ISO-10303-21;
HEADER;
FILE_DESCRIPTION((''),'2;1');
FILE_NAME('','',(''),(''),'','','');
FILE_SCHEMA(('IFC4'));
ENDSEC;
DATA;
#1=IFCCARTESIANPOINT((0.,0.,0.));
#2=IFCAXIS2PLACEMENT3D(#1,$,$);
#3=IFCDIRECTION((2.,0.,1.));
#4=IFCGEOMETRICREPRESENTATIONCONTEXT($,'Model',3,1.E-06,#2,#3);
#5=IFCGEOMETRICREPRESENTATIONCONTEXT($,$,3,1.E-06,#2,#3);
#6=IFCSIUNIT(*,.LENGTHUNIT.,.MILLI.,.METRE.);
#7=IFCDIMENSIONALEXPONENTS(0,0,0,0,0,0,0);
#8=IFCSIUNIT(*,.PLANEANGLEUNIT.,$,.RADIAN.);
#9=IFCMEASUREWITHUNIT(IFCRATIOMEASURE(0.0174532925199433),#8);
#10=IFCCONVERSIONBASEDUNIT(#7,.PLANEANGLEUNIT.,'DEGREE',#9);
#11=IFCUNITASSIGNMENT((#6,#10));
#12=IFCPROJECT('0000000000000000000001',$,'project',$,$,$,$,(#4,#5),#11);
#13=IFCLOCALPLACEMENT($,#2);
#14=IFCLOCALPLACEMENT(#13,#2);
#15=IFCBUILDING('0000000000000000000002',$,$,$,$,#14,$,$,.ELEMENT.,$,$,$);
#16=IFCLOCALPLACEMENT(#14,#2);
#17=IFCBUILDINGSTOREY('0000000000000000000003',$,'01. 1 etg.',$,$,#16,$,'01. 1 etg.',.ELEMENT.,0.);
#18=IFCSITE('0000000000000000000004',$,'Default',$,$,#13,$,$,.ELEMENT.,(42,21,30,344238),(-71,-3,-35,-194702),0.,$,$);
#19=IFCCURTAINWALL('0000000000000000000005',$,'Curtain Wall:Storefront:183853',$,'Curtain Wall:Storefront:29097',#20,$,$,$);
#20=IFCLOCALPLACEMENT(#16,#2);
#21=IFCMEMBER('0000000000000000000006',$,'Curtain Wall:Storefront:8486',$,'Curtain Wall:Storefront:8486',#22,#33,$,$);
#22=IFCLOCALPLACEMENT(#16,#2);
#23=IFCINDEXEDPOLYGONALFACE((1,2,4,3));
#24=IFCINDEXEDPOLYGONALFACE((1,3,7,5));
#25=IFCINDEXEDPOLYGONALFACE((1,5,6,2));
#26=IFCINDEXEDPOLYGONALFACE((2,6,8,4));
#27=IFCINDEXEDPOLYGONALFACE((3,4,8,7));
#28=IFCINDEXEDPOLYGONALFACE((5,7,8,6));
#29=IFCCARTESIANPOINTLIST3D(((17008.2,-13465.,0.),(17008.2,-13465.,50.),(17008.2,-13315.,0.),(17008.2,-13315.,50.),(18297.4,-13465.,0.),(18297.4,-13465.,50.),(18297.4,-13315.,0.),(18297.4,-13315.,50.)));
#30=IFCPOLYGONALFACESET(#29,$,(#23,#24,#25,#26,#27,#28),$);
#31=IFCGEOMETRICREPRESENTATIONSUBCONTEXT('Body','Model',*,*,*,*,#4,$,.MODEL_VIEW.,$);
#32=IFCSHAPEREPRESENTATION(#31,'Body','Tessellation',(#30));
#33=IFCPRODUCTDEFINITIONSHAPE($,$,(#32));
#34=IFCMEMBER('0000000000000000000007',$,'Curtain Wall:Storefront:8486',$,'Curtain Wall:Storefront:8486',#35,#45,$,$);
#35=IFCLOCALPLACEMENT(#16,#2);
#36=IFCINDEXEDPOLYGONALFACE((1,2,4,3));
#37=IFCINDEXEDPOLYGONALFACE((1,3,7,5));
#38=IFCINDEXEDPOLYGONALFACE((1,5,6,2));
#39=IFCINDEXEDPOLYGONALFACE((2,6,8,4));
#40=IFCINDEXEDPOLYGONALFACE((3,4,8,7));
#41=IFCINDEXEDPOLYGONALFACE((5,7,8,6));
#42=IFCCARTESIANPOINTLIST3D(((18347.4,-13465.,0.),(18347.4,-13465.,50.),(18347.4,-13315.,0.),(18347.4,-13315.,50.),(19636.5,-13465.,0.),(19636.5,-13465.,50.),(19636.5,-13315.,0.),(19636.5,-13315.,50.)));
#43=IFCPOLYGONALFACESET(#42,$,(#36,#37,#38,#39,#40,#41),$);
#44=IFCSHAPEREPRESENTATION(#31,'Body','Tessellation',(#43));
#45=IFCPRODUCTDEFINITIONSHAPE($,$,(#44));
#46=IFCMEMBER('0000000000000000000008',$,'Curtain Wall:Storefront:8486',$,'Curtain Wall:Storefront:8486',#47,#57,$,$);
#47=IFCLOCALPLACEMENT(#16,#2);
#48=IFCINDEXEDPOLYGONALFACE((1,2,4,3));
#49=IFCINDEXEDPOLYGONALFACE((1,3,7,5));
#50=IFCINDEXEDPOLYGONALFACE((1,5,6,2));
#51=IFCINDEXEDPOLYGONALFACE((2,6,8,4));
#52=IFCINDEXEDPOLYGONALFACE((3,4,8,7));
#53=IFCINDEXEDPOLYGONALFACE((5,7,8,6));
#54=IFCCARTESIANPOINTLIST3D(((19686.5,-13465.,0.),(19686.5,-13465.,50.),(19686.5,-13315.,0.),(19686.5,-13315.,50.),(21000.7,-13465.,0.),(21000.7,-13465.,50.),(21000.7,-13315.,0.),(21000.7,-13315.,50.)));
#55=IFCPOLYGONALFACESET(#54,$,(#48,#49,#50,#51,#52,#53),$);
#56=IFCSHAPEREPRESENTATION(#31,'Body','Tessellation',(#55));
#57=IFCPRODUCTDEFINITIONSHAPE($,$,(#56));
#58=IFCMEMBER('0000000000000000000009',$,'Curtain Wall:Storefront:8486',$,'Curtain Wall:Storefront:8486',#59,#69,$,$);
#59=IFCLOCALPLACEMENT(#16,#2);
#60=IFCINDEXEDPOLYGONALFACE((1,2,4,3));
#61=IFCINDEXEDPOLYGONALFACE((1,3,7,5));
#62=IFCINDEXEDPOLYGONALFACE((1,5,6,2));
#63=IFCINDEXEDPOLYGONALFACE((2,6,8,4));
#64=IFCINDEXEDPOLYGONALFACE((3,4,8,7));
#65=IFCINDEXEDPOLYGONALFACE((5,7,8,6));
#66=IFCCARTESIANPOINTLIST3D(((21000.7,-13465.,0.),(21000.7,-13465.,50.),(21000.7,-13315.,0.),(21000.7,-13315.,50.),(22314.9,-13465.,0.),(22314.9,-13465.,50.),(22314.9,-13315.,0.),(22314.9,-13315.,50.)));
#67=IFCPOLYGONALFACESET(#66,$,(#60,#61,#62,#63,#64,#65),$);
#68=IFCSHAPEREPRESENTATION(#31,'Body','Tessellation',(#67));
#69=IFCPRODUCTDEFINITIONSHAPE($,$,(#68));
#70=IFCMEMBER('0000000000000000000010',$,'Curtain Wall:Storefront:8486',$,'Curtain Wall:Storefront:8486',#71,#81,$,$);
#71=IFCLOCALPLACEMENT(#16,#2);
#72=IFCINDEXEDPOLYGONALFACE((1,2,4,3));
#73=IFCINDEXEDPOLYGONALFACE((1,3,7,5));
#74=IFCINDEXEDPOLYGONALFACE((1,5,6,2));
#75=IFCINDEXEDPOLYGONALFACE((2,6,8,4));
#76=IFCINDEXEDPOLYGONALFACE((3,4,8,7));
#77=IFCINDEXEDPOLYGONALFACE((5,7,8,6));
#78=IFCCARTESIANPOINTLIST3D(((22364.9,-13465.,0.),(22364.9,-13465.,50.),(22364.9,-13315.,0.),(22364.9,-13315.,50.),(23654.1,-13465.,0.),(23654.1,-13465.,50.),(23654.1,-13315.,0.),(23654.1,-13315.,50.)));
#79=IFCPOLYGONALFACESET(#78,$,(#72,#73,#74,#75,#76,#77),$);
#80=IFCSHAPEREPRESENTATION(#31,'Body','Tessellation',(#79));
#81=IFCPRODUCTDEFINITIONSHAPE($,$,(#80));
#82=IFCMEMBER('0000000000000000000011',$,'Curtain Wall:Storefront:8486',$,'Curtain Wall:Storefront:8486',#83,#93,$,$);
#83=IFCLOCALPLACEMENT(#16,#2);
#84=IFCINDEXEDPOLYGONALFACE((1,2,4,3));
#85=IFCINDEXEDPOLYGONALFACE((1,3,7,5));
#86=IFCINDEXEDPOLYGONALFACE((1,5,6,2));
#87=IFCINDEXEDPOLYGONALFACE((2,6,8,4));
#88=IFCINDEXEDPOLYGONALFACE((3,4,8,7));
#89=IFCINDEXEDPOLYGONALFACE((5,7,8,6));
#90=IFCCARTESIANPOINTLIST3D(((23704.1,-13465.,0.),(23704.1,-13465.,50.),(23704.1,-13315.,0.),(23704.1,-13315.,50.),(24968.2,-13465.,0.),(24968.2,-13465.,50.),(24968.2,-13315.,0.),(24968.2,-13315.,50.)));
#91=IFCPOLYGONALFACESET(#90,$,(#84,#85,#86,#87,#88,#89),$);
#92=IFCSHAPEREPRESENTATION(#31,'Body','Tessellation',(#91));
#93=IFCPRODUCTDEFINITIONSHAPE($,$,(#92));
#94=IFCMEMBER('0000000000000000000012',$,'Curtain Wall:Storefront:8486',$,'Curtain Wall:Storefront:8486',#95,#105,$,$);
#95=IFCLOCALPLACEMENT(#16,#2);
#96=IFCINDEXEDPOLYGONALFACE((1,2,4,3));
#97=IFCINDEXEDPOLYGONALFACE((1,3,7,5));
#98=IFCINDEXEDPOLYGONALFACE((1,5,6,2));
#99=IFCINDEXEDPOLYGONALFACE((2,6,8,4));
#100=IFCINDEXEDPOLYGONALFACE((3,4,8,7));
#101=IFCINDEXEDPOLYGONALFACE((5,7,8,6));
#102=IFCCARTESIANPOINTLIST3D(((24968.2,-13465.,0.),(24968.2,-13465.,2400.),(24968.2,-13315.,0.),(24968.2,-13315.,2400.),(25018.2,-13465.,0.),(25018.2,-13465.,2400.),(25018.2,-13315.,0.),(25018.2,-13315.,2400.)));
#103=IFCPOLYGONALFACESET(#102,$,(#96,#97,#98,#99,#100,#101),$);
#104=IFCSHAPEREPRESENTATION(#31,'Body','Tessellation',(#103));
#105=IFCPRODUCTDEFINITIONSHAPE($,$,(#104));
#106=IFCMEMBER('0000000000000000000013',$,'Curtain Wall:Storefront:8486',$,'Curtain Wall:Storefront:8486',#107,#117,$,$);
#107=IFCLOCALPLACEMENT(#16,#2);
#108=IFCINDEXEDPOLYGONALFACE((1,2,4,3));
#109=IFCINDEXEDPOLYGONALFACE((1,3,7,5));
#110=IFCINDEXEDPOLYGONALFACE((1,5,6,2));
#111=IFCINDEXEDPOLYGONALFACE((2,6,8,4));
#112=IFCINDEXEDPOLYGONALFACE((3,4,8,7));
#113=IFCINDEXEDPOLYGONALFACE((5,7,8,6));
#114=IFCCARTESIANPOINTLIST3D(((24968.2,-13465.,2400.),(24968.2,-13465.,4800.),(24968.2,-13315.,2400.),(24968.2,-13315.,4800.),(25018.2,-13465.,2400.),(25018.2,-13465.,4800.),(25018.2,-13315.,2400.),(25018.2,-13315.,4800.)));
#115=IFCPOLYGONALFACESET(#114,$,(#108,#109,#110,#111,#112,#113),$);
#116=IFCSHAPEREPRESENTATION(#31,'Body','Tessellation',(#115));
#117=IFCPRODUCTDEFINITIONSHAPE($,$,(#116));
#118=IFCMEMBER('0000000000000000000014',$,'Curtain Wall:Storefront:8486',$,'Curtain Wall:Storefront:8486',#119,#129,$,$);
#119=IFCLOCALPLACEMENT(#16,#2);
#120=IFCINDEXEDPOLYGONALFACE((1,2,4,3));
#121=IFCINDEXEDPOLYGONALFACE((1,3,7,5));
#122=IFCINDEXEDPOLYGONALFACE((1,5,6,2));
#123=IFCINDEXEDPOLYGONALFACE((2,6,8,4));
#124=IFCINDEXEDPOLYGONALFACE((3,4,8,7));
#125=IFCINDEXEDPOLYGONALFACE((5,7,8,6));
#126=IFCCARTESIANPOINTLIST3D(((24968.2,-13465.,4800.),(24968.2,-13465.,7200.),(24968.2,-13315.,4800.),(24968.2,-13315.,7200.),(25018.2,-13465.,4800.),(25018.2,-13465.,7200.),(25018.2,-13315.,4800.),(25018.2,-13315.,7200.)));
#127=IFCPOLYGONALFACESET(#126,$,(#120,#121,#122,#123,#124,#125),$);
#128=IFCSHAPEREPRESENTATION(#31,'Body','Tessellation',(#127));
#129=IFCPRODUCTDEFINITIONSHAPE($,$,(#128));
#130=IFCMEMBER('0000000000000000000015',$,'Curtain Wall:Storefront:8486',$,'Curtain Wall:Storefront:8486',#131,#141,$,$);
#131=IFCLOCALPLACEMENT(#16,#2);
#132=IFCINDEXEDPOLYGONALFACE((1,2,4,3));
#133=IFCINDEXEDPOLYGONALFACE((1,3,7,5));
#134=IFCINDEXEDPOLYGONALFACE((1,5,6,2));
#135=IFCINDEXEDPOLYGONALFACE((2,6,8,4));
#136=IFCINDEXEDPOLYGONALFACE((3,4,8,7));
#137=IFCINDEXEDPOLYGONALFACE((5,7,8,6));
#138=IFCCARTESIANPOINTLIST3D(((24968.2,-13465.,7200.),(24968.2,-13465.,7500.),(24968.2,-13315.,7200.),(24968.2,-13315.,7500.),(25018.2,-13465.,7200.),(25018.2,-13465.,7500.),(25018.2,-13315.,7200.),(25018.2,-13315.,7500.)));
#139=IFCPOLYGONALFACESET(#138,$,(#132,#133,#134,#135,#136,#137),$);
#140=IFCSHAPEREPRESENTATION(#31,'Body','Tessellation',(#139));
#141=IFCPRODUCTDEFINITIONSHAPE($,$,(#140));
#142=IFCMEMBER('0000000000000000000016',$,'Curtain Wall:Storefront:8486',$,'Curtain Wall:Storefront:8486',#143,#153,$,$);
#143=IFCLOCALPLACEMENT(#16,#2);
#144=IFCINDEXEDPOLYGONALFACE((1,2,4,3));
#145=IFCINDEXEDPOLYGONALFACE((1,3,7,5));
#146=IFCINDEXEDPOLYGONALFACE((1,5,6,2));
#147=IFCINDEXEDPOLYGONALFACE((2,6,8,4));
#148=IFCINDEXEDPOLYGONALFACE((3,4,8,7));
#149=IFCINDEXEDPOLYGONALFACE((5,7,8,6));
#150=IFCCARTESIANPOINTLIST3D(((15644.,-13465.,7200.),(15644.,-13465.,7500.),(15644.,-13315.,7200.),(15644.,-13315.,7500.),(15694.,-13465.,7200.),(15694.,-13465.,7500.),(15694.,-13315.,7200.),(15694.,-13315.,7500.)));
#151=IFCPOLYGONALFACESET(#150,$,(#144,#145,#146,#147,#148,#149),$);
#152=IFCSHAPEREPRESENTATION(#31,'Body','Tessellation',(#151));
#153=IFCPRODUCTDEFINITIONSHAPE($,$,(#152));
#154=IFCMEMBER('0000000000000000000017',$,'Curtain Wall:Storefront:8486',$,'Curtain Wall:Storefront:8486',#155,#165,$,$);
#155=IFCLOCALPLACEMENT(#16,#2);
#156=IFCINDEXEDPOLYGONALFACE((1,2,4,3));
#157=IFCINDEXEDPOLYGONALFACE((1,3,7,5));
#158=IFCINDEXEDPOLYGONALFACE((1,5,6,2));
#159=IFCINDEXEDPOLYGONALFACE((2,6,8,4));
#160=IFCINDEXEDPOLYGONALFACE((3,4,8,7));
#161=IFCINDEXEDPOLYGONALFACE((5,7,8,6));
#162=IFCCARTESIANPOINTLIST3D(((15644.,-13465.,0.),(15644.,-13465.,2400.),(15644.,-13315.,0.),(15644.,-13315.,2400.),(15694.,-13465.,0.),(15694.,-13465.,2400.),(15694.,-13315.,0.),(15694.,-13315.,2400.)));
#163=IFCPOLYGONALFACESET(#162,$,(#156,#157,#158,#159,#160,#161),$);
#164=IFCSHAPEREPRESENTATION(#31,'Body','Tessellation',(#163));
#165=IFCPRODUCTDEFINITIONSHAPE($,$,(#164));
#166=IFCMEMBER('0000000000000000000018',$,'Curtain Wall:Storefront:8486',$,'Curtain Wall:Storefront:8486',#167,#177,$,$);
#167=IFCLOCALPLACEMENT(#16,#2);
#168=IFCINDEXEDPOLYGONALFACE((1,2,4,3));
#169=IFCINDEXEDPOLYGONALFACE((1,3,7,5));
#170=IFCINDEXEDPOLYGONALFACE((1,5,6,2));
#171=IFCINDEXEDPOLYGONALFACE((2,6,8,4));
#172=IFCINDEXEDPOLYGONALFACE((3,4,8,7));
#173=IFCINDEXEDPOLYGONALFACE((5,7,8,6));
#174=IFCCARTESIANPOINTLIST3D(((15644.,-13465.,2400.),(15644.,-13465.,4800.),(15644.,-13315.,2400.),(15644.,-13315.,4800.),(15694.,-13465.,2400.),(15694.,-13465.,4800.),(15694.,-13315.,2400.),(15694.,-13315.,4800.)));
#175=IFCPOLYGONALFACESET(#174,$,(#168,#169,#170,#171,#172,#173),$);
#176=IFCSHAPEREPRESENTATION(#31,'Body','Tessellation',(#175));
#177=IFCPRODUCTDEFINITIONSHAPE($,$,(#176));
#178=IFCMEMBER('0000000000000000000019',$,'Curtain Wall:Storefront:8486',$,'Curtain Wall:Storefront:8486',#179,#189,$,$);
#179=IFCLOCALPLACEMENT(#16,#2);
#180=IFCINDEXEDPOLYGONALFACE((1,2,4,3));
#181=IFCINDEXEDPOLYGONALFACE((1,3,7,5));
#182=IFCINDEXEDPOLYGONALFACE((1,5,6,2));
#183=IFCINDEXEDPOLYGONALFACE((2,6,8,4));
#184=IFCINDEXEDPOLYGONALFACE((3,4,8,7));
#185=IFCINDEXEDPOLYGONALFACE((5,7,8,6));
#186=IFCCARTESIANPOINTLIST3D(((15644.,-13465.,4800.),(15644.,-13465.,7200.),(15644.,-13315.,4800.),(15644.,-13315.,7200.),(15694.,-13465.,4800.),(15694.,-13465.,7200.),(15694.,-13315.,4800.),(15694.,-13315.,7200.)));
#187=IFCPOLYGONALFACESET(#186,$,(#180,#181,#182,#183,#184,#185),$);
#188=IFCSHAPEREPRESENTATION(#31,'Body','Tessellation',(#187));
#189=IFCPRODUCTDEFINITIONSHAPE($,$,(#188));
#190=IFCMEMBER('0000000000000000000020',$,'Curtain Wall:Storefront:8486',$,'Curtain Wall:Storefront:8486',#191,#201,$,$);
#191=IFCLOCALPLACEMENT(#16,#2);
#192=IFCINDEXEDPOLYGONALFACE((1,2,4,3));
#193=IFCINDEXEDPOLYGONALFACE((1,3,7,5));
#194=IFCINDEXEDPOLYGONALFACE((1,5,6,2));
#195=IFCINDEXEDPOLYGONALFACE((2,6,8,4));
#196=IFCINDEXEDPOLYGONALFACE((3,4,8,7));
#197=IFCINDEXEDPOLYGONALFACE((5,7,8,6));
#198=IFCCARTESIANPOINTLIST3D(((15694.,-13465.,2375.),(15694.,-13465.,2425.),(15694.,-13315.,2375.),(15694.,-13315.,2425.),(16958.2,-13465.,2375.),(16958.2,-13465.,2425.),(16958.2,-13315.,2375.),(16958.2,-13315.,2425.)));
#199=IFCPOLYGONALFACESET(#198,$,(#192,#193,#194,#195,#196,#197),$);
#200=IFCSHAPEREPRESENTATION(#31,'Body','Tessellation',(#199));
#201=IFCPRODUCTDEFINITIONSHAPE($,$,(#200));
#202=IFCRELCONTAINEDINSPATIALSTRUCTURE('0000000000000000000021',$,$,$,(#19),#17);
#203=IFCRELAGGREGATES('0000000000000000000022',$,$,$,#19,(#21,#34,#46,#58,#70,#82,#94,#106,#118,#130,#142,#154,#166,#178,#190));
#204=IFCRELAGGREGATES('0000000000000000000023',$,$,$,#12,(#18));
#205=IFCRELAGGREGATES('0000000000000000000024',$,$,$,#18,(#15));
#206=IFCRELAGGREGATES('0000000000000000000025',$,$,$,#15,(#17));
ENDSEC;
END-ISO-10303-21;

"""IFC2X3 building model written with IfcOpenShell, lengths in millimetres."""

from ifc_helpers import new_model, entity, si_unit, converted_unit, direction, frame, frame_2d, origin, origin_2d_with_axis, place, context, subcontext, project, spatial, rectangle, extrude, element, aggregate, save


model = new_model("IFC2X3")

# Units and contexts
model_context = context("Model", 3, precision=1e-06, world=origin(), true_north=direction((2.0, 0.0, 1.0)))
context_of_model = context(None, 3, precision=1e-06, world=origin(), true_north=direction((2.0, 0.0, 1.0)))
body_context = subcontext(model_context, "Body", "Model", "MODEL_VIEW")
ifc_project = project(units=[si_unit("LENGTHUNIT", "METRE", prefix="MILLI"), converted_unit("PLANEANGLEUNIT", "DEGREE", entity("IfcRatioMeasure", 0.0174532925199433), si_unit("PLANEANGLEUNIT", "RADIAN"), dimensions=[0, 0, 0, 0, 0, 0, 0])], contexts=[model_context, context_of_model])

# Site, building, storey
site_placement = place(None, origin())
site = spatial("IfcSite", under=ifc_project, at=site_placement, Name="Default", CompositionType="ELEMENT", RefLatitude=(42, 21, 30, 344238), RefLongitude=(-71, -3, -35, -194702), RefElevation=0.0)
building_placement = place(site_placement, origin())
building = spatial("IfcBuilding", under=site, at=building_placement, CompositionType="ELEMENT")
storey_placement = place(building_placement, origin())
storey = spatial("IfcBuildingStorey", under=building, at=storey_placement, Name="01. 1 etg.", LongName="01. 1 etg.", CompositionType="ELEMENT", Elevation=0.0)

# Curtain wall, members
curtain_wall_placement = place(storey_placement, origin())
curtain_wall = element("IfcCurtainWall", 1, at=curtain_wall_placement, inside=storey, Name="Curtain Wall:Storefront:183853", ObjectType="Curtain Wall:Storefront:29097")
member_1_placement = place(storey_placement, origin())
member_1 = element("IfcMember", 2, at=member_1_placement, Name="Curtain Wall:Storefront:8486", ObjectType="Curtain Wall:Storefront:8486", context=body_context, shape_type="SweptSolid", body=[
    extrude(rectangle(XDim=1289.2, YDim=150.0, at=frame_2d((0.0, 0.0), x_axis=(1.0, 0.0))), frame((17652.8, -13390.0, 0.0)), (0.0, 0.0, 1.0), 50.0),
])
member_2_placement = place(storey_placement, origin())
member_2 = element("IfcMember", 3, at=member_2_placement, Name="Curtain Wall:Storefront:8486", ObjectType="Curtain Wall:Storefront:8486", context=body_context, shape_type="SweptSolid", body=[
    extrude(rectangle(XDim=1289.2, YDim=150.0, at=frame_2d((0.0, 0.0), x_axis=(1.0, 0.0))), frame((18991.9, -13390.0, 0.0)), (0.0, 0.0, 1.0), 50.0),
])
member_3_placement = place(storey_placement, origin())
member_3 = element("IfcMember", 4, at=member_3_placement, Name="Curtain Wall:Storefront:8486", ObjectType="Curtain Wall:Storefront:8486", context=body_context, shape_type="SweptSolid", body=[
    extrude(rectangle(XDim=1314.2, YDim=150.0, at=origin_2d_with_axis()), frame((20343.6, -13390.0, 0.0)), (0.0, 0.0, 1.0), 50.0),
])
member_4_placement = place(storey_placement, origin())
member_4 = element("IfcMember", 5, at=member_4_placement, Name="Curtain Wall:Storefront:8486", ObjectType="Curtain Wall:Storefront:8486", context=body_context, shape_type="SweptSolid", body=[
    extrude(rectangle(XDim=1314.2, YDim=150.0, at=frame_2d((0.0, 0.0), x_axis=(1.0, 0.0))), frame((21657.8, -13390.0, 0.0)), (0.0, 0.0, 1.0), 50.0),
])
member_5_placement = place(storey_placement, origin())
member_5 = element("IfcMember", 6, at=member_5_placement, Name="Curtain Wall:Storefront:8486", ObjectType="Curtain Wall:Storefront:8486", context=body_context, shape_type="SweptSolid", body=[
    extrude(rectangle(XDim=1289.2, YDim=150.0, at=origin_2d_with_axis()), frame((23009.5, -13390.0, 0.0)), (0.0, 0.0, 1.0), 50.0),
])
member_6_placement = place(storey_placement, origin())
member_6 = element("IfcMember", 7, at=member_6_placement, Name="Curtain Wall:Storefront:8486", ObjectType="Curtain Wall:Storefront:8486", context=body_context, shape_type="SweptSolid", body=[
    extrude(rectangle(XDim=1264.2, YDim=150.0, at=frame_2d((0.0, 0.0), x_axis=(1.0, 0.0))), frame((24336.1, -13390.0, 0.0)), (0.0, 0.0, 1.0), 50.0),
])
member_7_placement = place(storey_placement, origin())
member_7 = element("IfcMember", 8, at=member_7_placement, Name="Curtain Wall:Storefront:8486", ObjectType="Curtain Wall:Storefront:8486", context=body_context, shape_type="SweptSolid", body=[
    extrude(rectangle(XDim=150.0, YDim=50.0, at=frame_2d((0.0, 0.0), x_axis=(1.0, 0.0))), frame((24993.2, -13390.0, 0.0), z_axis=(0.0, 0.0, 1.0), x_axis=(0.0, 1.0, 0.0)), (0.0, 0.0, 1.0), 2400.0),
])
member_8_placement = place(storey_placement, origin())
member_8 = element("IfcMember", 9, at=member_8_placement, Name="Curtain Wall:Storefront:8486", ObjectType="Curtain Wall:Storefront:8486", context=body_context, shape_type="SweptSolid", body=[
    extrude(rectangle(XDim=150.0, YDim=50.0, at=frame_2d((0.0, 0.0), x_axis=(1.0, 0.0))), frame((24993.2, -13390.0, 2400.0), z_axis=(0.0, 0.0, 1.0), x_axis=(0.0, 1.0, 0.0)), (0.0, 0.0, 1.0), 2400.0),
])
member_9_placement = place(storey_placement, origin())
member_9 = element("IfcMember", 10, at=member_9_placement, Name="Curtain Wall:Storefront:8486", ObjectType="Curtain Wall:Storefront:8486", context=body_context, shape_type="SweptSolid", body=[
    extrude(rectangle(XDim=150.0, YDim=50.0, at=frame_2d((0.0, 0.0), x_axis=(1.0, 0.0))), frame((24993.2, -13390.0, 4800.0), z_axis=(0.0, 0.0, 1.0), x_axis=(0.0, 1.0, 0.0)), (0.0, 0.0, 1.0), 2400.0),
])
member_10_placement = place(storey_placement, origin())
member_10 = element("IfcMember", 11, at=member_10_placement, Name="Curtain Wall:Storefront:8486", ObjectType="Curtain Wall:Storefront:8486", context=body_context, shape_type="SweptSolid", body=[
    extrude(rectangle(XDim=150.0, YDim=50.0, at=frame_2d((0.0, 0.0), x_axis=(1.0, 0.0))), frame((24993.2, -13390.0, 7200.0), z_axis=(0.0, 0.0, 1.0), x_axis=(0.0, 1.0, 0.0)), (0.0, 0.0, 1.0), 300.0),
])
member_11_placement = place(storey_placement, origin())
member_11 = element("IfcMember", 12, at=member_11_placement, Name="Curtain Wall:Storefront:8486", ObjectType="Curtain Wall:Storefront:8486", context=body_context, shape_type="SweptSolid", body=[
    extrude(rectangle(XDim=50.0, YDim=150.0, at=origin_2d_with_axis()), frame((15669.0, -13390.0, 7200.0)), (0.0, 0.0, 1.0), 300.0),
])
member_12_placement = place(storey_placement, origin())
member_12 = element("IfcMember", 13, at=member_12_placement, Name="Curtain Wall:Storefront:8486", ObjectType="Curtain Wall:Storefront:8486", context=body_context, shape_type="SweptSolid", body=[
    extrude(rectangle(XDim=50.0, YDim=150.0, at=origin_2d_with_axis()), frame((15669.0, -13390.0, 0.0)), (0.0, 0.0, 1.0), 2400.0),
])
member_13_placement = place(storey_placement, origin())
member_13 = element("IfcMember", 14, at=member_13_placement, Name="Curtain Wall:Storefront:8486", ObjectType="Curtain Wall:Storefront:8486", context=body_context, shape_type="SweptSolid", body=[
    extrude(rectangle(XDim=50.0, YDim=150.0, at=origin_2d_with_axis()), frame((15669.0, -13390.0, 2400.0)), (0.0, 0.0, 1.0), 2400.0),
])
member_14_placement = place(storey_placement, origin())
member_14 = element("IfcMember", 15, at=member_14_placement, Name="Curtain Wall:Storefront:8486", ObjectType="Curtain Wall:Storefront:8486", context=body_context, shape_type="SweptSolid", body=[
    extrude(rectangle(XDim=50.0, YDim=150.0, at=origin_2d_with_axis()), frame((15669.0, -13390.0, 4800.0)), (0.0, 0.0, 1.0), 2400.0),
])
member_15_placement = place(storey_placement, origin())
member_15 = element("IfcMember", 16, at=member_15_placement, Name="Curtain Wall:Storefront:8486", ObjectType="Curtain Wall:Storefront:8486", context=body_context, shape_type="SweptSolid", body=[
    extrude(rectangle(XDim=1264.2, YDim=150.0, at=frame_2d((0.0, 0.0), x_axis=(1.0, 0.0))), frame((16326.1, -13390.0, 2375.0), z_axis=(0.0, 0.0, 1.0), x_axis=(-1.0, 0.0, 0.0)), (0.0, 0.0, 1.0), 50.0),
])
aggregate(curtain_wall, [member_1, member_2, member_3, member_4, member_5, member_6, member_7, member_8, member_9, member_10, member_11, member_12, member_13, member_14, member_15])

save(model, "model.ifc")
